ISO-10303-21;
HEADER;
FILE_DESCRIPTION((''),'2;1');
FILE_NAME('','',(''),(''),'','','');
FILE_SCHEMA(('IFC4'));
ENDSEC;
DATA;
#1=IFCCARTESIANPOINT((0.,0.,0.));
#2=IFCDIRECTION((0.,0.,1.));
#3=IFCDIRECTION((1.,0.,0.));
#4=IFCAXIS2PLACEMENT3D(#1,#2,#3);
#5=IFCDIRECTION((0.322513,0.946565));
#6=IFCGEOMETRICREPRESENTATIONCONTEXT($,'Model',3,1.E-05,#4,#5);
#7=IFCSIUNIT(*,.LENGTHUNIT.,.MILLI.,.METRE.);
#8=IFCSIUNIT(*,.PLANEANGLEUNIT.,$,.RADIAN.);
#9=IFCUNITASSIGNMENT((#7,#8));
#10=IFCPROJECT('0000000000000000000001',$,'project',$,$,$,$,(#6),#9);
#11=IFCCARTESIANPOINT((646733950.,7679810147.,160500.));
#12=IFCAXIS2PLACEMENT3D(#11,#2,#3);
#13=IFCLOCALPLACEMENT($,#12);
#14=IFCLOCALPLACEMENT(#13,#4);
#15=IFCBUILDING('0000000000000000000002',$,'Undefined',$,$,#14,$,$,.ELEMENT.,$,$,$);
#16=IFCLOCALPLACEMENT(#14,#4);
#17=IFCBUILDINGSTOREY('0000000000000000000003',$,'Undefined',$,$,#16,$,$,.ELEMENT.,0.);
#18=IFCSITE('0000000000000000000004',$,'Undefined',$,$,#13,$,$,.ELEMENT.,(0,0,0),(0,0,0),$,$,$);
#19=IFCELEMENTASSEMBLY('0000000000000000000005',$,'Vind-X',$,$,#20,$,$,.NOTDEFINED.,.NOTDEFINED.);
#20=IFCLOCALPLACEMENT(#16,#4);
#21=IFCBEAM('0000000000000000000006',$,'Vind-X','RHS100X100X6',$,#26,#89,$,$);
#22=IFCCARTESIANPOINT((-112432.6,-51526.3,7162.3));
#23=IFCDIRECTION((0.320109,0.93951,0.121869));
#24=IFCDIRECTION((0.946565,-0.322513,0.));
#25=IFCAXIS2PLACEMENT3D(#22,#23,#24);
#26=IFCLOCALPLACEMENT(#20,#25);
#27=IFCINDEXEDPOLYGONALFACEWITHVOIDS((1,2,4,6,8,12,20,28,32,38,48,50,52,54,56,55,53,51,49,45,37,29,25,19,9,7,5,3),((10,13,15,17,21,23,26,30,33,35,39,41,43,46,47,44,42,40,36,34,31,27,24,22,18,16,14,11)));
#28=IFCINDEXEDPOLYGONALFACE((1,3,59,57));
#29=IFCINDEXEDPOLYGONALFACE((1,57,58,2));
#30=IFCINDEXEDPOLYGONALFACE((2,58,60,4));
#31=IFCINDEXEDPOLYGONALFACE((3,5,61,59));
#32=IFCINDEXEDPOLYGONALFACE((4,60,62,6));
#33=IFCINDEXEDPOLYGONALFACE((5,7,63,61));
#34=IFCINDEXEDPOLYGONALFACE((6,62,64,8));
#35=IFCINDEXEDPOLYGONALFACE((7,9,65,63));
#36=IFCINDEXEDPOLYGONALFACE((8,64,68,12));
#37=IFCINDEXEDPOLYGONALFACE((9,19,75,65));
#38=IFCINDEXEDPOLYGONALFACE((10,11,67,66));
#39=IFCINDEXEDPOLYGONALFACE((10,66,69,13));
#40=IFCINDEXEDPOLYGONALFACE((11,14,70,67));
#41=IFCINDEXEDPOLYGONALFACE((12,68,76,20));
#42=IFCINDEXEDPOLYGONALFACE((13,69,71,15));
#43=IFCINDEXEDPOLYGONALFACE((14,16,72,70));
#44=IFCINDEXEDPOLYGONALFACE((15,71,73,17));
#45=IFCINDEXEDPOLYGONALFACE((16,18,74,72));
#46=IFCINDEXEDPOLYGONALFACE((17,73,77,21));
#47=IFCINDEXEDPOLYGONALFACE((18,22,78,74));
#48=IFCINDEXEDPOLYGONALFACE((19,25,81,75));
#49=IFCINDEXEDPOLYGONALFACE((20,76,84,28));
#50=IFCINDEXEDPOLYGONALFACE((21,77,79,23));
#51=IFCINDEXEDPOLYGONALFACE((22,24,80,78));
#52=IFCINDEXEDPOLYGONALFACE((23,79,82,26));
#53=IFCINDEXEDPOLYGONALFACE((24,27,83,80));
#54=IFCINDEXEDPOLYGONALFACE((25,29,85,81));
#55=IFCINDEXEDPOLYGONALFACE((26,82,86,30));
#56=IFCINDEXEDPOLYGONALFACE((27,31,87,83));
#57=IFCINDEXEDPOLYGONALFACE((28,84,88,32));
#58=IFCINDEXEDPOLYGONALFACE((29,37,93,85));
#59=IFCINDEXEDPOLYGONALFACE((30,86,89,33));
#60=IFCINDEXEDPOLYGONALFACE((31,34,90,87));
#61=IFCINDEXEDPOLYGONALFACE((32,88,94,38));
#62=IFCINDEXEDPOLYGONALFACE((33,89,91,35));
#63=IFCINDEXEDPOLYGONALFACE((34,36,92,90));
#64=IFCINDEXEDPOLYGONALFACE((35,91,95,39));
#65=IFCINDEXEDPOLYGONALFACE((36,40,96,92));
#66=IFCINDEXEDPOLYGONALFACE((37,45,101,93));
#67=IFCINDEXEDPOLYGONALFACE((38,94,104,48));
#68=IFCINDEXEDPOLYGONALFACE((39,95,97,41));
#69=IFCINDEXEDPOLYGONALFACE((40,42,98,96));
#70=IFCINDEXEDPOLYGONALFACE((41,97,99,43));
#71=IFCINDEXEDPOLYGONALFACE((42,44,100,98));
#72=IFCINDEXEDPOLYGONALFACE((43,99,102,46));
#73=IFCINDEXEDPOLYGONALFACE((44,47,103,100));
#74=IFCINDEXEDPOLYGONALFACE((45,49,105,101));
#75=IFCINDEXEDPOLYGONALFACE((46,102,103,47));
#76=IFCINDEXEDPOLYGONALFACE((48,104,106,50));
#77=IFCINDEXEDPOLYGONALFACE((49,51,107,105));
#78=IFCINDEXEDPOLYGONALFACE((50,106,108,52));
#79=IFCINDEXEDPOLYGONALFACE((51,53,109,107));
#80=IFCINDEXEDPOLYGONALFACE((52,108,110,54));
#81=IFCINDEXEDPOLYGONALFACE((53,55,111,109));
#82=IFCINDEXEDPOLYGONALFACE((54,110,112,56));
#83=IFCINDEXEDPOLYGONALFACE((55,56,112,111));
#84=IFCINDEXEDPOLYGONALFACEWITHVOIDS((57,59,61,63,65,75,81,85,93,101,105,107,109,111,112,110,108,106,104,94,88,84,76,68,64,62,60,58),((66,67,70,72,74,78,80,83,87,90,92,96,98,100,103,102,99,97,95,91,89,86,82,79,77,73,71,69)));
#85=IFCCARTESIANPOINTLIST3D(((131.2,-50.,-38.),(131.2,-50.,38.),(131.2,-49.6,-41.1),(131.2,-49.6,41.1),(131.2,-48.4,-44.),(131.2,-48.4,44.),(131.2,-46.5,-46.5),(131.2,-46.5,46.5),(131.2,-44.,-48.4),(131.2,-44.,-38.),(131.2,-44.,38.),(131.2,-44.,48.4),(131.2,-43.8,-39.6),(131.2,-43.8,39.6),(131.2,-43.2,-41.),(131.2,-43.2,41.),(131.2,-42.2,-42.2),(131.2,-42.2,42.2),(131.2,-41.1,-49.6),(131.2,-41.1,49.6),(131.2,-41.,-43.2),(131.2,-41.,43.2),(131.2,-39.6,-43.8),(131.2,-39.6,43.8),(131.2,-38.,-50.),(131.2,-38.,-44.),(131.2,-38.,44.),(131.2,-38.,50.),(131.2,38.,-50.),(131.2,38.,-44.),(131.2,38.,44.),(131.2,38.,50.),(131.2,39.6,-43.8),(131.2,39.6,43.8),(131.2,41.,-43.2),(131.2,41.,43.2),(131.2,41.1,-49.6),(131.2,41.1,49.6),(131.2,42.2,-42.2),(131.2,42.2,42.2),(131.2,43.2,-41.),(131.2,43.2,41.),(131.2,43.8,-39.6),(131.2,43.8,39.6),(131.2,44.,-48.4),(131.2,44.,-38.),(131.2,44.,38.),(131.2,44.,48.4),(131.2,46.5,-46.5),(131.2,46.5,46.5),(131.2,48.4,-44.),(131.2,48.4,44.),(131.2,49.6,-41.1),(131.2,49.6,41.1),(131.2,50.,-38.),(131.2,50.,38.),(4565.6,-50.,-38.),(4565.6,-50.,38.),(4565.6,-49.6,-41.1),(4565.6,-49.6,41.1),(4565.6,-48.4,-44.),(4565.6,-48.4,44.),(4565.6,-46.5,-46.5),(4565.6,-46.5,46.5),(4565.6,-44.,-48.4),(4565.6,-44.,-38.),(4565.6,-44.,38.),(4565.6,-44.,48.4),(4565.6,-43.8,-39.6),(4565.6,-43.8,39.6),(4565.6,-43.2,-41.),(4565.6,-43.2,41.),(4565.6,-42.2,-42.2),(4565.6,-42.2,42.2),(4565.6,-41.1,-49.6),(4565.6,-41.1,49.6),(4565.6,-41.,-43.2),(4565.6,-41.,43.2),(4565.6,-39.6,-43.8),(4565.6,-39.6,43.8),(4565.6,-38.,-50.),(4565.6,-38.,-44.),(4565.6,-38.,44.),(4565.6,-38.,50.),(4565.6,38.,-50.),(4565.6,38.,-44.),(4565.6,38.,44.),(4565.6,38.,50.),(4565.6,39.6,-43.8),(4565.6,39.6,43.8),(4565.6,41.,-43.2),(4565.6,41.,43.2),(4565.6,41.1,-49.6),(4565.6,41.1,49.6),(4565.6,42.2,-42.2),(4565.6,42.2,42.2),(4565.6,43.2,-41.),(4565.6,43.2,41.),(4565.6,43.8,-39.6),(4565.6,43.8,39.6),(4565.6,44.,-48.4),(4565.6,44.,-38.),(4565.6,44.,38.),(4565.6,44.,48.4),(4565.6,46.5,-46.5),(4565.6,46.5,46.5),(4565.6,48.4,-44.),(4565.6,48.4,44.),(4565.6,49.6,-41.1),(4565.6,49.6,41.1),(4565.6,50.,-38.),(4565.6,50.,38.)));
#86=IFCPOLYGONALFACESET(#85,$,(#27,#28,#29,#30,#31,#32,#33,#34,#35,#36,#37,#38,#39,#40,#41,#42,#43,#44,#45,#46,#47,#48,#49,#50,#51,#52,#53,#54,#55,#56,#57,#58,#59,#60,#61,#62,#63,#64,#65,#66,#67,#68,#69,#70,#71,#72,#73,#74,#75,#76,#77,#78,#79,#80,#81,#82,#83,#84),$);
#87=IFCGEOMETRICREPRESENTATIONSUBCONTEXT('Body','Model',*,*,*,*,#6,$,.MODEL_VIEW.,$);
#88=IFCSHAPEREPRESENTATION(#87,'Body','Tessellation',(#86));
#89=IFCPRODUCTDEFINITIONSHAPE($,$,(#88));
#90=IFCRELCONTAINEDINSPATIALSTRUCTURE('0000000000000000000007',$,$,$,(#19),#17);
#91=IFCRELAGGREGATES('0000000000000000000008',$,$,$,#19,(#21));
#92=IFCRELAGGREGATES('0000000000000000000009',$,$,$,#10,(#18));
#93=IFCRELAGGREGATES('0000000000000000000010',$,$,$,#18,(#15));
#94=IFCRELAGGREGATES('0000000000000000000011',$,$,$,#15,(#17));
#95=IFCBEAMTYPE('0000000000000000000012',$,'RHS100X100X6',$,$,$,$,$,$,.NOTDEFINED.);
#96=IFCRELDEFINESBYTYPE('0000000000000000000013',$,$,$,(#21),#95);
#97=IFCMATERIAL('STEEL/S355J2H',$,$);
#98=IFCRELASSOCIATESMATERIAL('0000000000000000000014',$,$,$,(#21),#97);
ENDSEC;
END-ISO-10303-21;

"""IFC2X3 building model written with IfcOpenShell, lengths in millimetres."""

from ifc_helpers import new_model, si_unit, direction, frame, origin_with_axes, origin_2d_with_axis, place, context, subcontext, project, spatial, hollow_rectangle, extrude, clip, halfspace, material, type_object, element, aggregate, save


model = new_model("IFC2X3")

# Units and contexts
model_context = context("Model", 3, precision=1e-05, world=origin_with_axes(), true_north=direction((0.322513, 0.946565)))
body_context = subcontext(model_context, "Body", "Model", "MODEL_VIEW")
ifc_project = project(units=[si_unit("LENGTHUNIT", "METRE", prefix="MILLI"), si_unit("PLANEANGLEUNIT", "RADIAN")], contexts=[model_context])

# Site, building, storey
site_placement = place(None, frame((646733950.0, 7679810147.0, 160500.0), z_axis=(0.0, 0.0, 1.0), x_axis=(1.0, 0.0, 0.0)))
site = spatial("IfcSite", under=ifc_project, at=site_placement, Name="Undefined", CompositionType="ELEMENT", RefLatitude=(0, 0, 0), RefLongitude=(0, 0, 0))
building_placement = place(site_placement, origin_with_axes())
building = spatial("IfcBuilding", under=site, at=building_placement, Name="Undefined", CompositionType="ELEMENT")
storey_placement = place(building_placement, origin_with_axes())
storey = spatial("IfcBuildingStorey", under=building, at=storey_placement, Name="Undefined", CompositionType="ELEMENT", Elevation=0.0)

# Element assembly, beam
ifc_material_1 = material(Name="STEEL/S355J2H")
beam_type_1 = type_object("IfcBeamType", Name="RHS100X100X6", PredefinedType="NOTDEFINED")
assembly_1_placement = place(storey_placement, origin_with_axes())
assembly_1 = element("IfcElementAssembly", 1, at=assembly_1_placement, inside=storey, Name="Vind-X", AssemblyPlace="NOTDEFINED", PredefinedType="NOTDEFINED")
beam_1_placement = place(assembly_1_placement, frame((-112432.6, -51526.3, 7162.3), z_axis=(0.320109, 0.93951, 0.121869), x_axis=(0.946565, -0.322513, 0.0)))
beam_1 = element("IfcBeam", 2, at=beam_1_placement, type_object=beam_type_1, material=ifc_material_1, Name="Vind-X", Description="RHS100X100X6", context=body_context, shape_type="Clipping", body=[
    clip(clip(extrude(hollow_rectangle(XDim=100.0, YDim=100.0, WallThickness=6.0, InnerFilletRadius=6.0, OuterFilletRadius=12.0, at=origin_2d_with_axis()), frame((4644.6, 0.0, 0.0), z_axis=(-1.0, 0.0, 0.0), x_axis=(0.0, -1.0, 0.0)), (0.0, 0.0, 1.0), 4644.6), halfspace(frame((4565.6, 22.5, 0.0), z_axis=(-1.0, 0.0, 0.0), x_axis=(0.0, 0.0, 1.0)), True)), halfspace(frame((131.2, 22.5, 0.0), z_axis=(1.0, 0.0, 0.0), x_axis=(0.0, 0.0, -1.0)), True)),
])

aggregate(assembly_1, [beam_1])

save(model, "model.ifc")
